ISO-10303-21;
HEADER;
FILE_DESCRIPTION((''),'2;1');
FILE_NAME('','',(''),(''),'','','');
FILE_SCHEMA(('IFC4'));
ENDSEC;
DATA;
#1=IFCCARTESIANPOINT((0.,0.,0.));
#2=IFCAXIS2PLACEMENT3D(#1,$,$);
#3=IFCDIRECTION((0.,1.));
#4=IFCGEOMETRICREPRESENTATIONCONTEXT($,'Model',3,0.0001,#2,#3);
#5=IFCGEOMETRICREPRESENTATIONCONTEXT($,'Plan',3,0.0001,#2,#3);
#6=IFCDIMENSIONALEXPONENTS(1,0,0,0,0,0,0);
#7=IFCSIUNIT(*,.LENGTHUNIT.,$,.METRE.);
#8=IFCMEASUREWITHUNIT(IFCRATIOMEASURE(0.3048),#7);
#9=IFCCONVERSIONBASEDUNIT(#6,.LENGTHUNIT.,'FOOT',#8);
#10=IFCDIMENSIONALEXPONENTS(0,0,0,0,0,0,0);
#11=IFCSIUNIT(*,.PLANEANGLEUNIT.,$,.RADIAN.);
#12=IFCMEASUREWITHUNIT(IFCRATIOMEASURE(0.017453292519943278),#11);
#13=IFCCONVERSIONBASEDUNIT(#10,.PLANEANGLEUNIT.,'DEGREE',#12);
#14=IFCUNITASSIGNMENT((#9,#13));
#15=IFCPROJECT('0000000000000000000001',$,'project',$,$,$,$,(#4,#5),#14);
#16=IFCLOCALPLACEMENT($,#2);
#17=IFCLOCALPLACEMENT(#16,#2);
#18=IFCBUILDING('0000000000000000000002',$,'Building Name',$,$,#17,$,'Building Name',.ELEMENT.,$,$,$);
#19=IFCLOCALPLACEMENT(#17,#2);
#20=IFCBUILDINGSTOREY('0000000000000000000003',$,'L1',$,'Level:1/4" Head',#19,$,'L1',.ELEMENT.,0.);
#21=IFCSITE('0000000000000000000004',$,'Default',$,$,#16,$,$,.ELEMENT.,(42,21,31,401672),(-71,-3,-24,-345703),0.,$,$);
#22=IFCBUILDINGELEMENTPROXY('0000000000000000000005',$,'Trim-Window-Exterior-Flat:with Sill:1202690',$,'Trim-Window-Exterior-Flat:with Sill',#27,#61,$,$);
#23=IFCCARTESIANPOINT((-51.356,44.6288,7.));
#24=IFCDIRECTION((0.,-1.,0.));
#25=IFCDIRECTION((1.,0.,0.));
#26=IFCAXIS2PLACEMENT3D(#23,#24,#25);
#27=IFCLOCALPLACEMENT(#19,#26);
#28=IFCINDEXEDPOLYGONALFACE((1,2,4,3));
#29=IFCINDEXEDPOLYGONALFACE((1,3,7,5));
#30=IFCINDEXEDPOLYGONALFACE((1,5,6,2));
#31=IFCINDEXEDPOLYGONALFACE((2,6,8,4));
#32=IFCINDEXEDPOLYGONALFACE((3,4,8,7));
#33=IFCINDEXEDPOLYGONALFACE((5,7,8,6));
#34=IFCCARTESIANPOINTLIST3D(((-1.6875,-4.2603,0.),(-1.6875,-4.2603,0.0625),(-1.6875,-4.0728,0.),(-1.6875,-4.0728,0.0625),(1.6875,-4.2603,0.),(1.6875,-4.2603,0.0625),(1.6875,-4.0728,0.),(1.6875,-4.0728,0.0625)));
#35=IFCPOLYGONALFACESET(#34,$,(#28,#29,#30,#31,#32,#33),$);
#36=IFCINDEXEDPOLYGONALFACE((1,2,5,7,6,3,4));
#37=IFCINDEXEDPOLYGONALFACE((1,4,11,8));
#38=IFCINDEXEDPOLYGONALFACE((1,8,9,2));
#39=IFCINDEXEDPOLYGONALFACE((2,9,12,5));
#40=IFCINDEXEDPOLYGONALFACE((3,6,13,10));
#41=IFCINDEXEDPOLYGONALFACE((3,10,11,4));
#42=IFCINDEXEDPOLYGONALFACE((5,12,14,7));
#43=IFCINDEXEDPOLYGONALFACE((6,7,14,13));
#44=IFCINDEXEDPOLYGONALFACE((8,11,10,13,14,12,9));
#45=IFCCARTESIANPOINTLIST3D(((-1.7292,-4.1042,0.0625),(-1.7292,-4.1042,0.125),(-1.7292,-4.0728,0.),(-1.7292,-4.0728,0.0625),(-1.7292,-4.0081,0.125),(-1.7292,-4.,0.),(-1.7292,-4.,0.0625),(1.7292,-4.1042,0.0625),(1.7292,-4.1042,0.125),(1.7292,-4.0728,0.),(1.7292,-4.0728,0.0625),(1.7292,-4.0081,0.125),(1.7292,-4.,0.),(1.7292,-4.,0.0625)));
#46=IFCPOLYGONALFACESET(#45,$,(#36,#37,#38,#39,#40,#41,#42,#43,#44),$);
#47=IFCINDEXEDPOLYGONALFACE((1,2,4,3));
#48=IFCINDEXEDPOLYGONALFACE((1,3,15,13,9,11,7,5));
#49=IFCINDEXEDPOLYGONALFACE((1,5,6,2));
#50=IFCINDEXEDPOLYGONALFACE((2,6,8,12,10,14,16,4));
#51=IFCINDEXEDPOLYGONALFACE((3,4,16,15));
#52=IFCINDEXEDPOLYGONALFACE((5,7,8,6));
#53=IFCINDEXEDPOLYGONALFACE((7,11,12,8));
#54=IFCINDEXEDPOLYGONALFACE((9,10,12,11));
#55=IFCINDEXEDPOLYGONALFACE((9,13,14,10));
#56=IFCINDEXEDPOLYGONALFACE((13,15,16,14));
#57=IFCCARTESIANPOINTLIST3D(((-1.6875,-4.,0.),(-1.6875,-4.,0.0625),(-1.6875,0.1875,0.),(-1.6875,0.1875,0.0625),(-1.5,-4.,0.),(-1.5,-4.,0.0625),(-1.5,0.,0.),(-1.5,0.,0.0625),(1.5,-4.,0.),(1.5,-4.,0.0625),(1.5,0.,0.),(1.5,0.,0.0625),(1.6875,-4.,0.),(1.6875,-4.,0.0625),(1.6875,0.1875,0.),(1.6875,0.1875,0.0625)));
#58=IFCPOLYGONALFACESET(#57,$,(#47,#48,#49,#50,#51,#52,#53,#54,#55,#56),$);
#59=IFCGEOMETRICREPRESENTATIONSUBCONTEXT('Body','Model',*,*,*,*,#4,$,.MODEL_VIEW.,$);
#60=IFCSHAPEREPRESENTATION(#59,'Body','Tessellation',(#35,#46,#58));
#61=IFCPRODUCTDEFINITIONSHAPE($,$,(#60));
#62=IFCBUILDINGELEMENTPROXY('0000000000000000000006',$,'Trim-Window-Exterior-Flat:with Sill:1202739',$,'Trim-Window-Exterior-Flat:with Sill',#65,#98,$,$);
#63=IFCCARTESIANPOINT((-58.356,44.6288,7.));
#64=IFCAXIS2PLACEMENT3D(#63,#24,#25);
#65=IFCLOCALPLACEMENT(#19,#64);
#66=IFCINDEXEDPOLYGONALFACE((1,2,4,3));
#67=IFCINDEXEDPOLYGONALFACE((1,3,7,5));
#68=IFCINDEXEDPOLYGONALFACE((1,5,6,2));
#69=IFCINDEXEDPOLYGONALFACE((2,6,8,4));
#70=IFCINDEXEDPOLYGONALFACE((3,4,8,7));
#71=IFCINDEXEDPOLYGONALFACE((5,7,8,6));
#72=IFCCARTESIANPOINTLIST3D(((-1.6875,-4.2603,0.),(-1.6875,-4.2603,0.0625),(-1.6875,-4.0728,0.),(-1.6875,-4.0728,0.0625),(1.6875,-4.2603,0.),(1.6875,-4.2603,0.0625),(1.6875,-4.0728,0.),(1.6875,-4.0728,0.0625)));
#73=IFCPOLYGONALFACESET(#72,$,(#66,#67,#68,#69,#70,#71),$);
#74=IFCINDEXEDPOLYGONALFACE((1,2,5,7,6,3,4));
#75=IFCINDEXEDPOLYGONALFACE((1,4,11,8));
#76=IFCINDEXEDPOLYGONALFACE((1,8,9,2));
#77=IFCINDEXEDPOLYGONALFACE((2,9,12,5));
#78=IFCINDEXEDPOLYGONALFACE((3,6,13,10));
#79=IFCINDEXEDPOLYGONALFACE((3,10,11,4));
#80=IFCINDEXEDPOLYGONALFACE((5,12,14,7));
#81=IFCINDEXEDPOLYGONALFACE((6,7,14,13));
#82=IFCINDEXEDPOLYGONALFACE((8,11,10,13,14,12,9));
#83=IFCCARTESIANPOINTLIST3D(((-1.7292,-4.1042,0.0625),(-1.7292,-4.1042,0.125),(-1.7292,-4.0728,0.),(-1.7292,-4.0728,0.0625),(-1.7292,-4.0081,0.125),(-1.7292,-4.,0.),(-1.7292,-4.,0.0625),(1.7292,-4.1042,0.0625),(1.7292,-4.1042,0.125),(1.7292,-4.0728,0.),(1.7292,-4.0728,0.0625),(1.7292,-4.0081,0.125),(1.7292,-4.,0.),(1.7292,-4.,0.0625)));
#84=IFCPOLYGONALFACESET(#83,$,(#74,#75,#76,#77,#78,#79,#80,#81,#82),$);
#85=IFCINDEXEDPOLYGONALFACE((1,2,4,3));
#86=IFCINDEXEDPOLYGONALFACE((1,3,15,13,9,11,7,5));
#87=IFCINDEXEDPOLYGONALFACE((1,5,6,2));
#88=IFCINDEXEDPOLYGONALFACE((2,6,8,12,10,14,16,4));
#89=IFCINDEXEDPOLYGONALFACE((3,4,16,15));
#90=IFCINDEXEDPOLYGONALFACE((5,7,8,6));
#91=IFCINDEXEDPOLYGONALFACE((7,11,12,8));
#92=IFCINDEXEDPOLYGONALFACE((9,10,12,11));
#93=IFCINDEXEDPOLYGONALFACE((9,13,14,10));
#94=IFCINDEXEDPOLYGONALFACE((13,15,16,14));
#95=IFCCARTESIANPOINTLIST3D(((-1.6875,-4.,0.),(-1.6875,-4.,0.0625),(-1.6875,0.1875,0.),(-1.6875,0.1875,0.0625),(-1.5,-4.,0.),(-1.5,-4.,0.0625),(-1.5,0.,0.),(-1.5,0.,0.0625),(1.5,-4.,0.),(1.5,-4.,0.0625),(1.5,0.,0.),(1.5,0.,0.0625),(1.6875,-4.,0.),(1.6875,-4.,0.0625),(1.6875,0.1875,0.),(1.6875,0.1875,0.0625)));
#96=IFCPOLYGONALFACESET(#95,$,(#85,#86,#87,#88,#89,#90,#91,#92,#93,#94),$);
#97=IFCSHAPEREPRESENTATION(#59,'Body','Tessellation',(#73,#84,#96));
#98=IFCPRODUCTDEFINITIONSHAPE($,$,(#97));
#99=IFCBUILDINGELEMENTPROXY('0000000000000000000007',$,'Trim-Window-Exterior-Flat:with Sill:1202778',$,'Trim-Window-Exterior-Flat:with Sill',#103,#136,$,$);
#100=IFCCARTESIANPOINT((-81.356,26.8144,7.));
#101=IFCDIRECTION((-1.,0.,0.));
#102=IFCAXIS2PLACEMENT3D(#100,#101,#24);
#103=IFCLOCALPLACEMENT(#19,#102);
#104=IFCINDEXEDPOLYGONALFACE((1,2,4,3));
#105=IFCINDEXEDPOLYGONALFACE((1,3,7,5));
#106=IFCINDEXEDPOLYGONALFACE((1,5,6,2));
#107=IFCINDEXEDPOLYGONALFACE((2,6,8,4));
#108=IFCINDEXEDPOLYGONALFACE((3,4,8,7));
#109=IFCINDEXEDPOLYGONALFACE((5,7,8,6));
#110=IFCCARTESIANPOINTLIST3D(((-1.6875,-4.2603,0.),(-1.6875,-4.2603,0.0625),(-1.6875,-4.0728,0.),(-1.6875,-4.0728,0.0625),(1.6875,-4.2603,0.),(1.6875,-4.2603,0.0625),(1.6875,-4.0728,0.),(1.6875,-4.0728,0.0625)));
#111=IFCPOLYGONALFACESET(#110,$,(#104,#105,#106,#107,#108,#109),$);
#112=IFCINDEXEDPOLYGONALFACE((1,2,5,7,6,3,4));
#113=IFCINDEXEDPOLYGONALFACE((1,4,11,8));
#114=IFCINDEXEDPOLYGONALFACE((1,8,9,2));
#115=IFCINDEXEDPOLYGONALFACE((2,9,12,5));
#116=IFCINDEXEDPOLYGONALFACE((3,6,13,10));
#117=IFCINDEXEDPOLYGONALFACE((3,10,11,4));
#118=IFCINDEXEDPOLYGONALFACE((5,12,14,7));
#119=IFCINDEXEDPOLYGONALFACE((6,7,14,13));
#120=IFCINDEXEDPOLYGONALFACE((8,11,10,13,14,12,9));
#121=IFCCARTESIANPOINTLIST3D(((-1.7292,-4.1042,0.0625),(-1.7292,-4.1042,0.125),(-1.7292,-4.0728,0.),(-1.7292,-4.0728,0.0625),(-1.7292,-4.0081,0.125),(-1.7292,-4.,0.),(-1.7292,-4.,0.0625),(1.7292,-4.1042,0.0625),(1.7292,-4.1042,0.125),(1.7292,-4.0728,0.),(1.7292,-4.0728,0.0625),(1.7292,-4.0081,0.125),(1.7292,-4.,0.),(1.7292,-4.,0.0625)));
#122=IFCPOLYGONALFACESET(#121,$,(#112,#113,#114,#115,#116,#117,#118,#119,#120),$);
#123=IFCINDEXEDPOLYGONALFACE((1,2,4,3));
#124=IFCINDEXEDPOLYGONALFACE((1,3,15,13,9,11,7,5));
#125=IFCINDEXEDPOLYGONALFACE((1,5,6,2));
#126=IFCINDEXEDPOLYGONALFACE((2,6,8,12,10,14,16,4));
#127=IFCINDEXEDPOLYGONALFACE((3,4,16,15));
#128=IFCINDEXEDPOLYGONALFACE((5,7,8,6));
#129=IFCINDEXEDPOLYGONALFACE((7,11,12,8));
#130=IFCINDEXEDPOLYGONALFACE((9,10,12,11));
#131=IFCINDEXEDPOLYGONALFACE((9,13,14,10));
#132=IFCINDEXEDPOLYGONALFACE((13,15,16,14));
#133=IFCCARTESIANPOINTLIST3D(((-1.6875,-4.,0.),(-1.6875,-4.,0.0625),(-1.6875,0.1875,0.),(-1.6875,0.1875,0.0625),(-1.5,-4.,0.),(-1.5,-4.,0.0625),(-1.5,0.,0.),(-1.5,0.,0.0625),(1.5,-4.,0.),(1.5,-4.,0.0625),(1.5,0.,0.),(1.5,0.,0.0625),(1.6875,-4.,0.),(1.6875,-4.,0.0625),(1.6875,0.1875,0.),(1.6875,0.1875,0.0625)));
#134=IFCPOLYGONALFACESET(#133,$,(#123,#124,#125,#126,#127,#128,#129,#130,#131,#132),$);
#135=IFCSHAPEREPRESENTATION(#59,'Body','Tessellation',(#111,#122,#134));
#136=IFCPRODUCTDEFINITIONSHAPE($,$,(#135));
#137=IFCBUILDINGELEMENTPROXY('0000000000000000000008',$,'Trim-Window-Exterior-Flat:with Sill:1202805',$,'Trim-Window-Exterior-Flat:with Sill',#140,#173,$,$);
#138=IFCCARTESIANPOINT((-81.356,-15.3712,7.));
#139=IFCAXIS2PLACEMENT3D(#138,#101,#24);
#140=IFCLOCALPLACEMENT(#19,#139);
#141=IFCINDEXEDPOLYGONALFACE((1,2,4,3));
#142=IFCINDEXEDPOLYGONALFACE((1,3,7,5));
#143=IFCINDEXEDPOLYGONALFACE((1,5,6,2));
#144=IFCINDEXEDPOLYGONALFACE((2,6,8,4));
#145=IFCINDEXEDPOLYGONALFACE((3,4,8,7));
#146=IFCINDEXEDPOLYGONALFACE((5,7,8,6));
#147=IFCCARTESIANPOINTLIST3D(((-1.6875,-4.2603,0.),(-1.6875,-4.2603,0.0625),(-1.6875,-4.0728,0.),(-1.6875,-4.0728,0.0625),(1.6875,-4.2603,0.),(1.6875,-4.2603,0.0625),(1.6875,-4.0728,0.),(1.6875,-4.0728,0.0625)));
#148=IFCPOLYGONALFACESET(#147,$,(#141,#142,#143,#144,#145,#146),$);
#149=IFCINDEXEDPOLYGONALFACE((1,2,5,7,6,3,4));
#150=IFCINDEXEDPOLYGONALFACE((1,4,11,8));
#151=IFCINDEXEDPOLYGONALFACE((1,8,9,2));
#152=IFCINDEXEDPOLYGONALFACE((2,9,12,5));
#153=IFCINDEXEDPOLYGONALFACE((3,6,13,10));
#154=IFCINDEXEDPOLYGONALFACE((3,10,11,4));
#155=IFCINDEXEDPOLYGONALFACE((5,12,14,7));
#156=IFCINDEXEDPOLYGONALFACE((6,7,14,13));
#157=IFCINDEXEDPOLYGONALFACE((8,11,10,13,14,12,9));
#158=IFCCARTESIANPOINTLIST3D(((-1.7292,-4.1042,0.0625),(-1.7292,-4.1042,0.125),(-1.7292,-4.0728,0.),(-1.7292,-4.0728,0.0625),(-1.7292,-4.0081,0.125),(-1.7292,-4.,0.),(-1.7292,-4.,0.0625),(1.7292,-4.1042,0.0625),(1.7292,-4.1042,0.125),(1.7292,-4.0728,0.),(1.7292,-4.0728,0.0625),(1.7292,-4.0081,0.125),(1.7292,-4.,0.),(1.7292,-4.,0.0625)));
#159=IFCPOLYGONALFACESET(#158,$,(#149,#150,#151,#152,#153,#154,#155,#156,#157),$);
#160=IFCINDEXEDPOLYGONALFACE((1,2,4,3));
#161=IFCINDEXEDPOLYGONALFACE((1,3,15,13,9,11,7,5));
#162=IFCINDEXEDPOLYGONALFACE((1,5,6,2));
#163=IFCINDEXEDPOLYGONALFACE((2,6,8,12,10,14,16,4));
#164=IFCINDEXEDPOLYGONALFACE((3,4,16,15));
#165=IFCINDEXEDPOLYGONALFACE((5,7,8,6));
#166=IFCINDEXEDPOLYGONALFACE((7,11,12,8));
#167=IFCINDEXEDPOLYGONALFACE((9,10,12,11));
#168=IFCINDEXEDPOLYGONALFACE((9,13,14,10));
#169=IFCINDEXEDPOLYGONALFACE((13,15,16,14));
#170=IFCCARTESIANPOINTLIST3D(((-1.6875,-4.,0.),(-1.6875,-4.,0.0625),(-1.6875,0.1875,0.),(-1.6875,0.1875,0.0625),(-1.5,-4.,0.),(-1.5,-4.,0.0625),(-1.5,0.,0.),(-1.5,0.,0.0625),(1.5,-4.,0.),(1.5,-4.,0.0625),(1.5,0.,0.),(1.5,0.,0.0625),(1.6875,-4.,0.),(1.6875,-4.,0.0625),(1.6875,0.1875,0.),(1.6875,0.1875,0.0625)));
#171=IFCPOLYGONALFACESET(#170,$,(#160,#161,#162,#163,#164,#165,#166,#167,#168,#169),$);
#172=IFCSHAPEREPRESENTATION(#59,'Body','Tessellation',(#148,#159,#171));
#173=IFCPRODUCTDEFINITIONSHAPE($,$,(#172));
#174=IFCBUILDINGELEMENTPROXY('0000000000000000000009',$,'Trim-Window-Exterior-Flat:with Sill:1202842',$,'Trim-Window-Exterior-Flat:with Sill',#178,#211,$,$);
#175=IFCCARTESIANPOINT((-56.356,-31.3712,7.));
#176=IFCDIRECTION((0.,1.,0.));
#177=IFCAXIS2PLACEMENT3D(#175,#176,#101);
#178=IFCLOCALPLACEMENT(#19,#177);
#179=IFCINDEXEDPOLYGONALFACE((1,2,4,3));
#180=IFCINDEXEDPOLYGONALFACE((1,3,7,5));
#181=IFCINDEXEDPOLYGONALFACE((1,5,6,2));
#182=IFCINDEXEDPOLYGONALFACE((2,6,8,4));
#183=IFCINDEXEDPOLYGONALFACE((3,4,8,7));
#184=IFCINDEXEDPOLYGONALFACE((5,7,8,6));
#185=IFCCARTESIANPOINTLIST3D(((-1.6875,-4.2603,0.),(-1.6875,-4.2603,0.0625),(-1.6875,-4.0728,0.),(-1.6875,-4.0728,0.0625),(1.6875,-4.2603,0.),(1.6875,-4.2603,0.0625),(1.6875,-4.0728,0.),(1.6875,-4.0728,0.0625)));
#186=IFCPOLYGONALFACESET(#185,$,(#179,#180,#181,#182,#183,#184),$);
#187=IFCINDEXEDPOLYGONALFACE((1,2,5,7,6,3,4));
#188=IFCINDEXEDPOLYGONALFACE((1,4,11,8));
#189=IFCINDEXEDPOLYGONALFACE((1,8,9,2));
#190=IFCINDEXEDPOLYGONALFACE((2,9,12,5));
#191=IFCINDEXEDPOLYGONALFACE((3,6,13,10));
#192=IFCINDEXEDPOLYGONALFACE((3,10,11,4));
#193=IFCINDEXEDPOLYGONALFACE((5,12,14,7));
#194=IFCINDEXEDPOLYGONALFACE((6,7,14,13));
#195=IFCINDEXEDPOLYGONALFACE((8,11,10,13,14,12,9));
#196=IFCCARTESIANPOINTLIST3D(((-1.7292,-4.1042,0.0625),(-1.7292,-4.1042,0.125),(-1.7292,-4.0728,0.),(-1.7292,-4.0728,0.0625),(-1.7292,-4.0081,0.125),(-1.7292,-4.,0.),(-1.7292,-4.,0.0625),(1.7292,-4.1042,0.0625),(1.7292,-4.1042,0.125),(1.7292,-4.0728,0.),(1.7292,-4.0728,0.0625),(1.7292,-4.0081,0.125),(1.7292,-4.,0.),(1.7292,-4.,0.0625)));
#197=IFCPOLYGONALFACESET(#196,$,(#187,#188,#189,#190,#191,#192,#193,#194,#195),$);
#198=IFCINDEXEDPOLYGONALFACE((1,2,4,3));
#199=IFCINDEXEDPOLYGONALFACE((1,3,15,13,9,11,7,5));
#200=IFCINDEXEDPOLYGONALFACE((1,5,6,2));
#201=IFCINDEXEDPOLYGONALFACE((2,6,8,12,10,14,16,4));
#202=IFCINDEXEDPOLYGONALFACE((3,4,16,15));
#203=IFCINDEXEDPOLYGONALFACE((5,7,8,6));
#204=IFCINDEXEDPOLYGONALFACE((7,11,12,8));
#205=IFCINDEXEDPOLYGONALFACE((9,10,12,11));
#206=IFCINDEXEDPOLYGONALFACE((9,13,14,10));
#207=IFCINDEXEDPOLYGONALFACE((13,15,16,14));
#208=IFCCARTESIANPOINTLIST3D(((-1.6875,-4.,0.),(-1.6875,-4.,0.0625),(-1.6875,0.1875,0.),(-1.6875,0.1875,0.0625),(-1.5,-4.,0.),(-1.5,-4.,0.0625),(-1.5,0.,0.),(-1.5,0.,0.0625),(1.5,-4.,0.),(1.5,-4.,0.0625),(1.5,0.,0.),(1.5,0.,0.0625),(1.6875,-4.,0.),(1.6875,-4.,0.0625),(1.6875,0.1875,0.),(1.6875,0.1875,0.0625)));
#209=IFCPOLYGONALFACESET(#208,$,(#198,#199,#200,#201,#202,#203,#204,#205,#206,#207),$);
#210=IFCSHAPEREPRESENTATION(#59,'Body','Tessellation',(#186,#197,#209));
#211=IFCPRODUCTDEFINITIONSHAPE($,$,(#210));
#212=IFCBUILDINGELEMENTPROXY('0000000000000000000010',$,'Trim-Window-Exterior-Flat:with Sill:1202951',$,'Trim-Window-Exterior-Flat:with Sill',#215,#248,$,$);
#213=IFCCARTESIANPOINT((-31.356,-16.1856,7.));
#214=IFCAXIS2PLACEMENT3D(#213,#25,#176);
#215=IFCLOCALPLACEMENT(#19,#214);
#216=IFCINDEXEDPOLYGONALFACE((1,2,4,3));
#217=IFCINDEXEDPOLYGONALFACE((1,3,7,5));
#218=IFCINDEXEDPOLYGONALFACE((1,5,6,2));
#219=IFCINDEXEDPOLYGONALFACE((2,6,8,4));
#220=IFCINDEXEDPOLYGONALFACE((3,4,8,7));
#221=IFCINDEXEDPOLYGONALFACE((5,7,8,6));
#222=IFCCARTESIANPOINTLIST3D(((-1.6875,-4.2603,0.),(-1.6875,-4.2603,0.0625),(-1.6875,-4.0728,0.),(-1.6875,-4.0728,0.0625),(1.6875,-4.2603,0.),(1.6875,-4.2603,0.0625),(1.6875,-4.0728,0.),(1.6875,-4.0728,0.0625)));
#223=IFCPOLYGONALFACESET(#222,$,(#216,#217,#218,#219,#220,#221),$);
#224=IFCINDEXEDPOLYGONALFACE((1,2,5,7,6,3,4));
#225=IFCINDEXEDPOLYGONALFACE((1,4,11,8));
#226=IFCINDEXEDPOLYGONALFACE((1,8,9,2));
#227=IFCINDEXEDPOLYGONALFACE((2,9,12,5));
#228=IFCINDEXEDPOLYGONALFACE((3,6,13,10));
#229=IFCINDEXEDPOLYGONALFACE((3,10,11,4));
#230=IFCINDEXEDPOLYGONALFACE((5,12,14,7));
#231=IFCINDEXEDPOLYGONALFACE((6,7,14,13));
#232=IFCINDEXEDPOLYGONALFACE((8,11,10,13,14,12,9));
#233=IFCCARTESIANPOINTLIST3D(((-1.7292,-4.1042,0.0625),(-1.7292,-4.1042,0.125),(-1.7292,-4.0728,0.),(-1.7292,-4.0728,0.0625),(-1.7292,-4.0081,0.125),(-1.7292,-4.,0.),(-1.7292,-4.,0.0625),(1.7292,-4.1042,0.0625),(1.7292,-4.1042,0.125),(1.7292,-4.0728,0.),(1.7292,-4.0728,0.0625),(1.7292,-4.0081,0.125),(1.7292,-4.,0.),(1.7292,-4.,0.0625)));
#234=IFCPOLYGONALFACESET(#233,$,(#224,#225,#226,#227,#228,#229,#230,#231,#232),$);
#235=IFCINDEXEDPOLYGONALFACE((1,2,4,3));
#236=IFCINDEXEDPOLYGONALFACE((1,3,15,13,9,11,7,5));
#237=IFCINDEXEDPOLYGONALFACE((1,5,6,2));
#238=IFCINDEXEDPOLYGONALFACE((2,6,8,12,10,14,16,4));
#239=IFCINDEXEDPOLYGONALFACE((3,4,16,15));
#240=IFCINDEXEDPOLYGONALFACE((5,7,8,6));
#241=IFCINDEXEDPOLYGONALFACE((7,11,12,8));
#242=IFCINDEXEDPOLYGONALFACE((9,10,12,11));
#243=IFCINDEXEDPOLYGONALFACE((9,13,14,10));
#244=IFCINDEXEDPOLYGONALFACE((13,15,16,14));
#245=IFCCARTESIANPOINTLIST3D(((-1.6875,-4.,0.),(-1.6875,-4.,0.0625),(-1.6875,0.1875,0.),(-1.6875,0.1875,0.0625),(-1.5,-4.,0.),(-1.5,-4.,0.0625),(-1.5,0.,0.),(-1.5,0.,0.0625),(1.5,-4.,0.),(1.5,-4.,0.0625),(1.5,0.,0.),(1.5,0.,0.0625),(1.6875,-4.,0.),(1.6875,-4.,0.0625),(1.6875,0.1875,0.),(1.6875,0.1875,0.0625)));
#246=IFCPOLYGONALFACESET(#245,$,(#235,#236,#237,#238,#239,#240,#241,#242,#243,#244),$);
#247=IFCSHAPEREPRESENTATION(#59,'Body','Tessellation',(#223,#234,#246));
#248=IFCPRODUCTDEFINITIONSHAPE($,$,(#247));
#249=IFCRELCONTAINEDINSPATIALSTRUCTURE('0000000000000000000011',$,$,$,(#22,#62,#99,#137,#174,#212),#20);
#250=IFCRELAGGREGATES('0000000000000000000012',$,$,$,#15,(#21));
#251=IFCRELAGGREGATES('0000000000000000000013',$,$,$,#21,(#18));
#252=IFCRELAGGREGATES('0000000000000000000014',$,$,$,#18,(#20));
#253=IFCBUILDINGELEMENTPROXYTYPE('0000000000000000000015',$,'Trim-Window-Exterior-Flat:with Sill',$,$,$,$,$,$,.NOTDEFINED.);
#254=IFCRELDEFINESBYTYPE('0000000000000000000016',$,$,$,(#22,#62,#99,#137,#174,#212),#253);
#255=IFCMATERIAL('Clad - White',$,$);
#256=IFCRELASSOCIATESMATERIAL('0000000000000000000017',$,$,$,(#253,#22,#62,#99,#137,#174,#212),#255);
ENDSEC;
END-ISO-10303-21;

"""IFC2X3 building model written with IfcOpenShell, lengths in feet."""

from ifc_helpers import new_model, entity, si_unit, converted_unit, direction, frame, frame_2d, origin, place, context, subcontext, project, spatial, polyline, rectangle, outline, extrude, source, transform, mapped, material, type_object, type_shapes, element, save


model = new_model("IFC2X3")

# Units and contexts
model_context = context("Model", 3, precision=0.0001, world=origin(), true_north=direction((0.0, 1.0)))
plan_context = context("Plan", 3, precision=0.0001, world=origin(), true_north=direction((0.0, 1.0)))
body_context = subcontext(model_context, "Body", "Model", "MODEL_VIEW")
ifc_project = project(units=[converted_unit("LENGTHUNIT", "FOOT", entity("IfcRatioMeasure", 0.3048), si_unit("LENGTHUNIT", "METRE"), dimensions=[1, 0, 0, 0, 0, 0, 0]), converted_unit("PLANEANGLEUNIT", "DEGREE", entity("IfcRatioMeasure", 0.017453292519943278), si_unit("PLANEANGLEUNIT", "RADIAN"), dimensions=[0, 0, 0, 0, 0, 0, 0])], contexts=[model_context, plan_context])

# Site, building, storey
site_placement = place(None, origin())
site = spatial("IfcSite", under=ifc_project, at=site_placement, Name="Default", CompositionType="ELEMENT", RefLatitude=(42, 21, 31, 401672), RefLongitude=(-71, -3, -24, -345703), RefElevation=0.0)
building_placement = place(site_placement, origin())
building = spatial("IfcBuilding", under=site, at=building_placement, Name="Building Name", LongName="Building Name", CompositionType="ELEMENT")
storey_placement = place(building_placement, origin())
storey = spatial("IfcBuildingStorey", under=building, at=storey_placement, Name="L1", ObjectType="Level:1/4\" Head", LongName="L1", CompositionType="ELEMENT", Elevation=0.0)

# Building element proxies
ifc_material_1 = material(Name="Clad - White")
building_element_proxy_type_1 = type_object("IfcBuildingElementProxyType", Name="Trim-Window-Exterior-Flat:with Sill", PredefinedType="NOTDEFINED", material=ifc_material_1)
shared_shape_1 = source(origin(), body_context, "Body", "SweptSolid", [
    extrude(rectangle(XDim=3.375, YDim=0.1875, at=frame_2d((0.0, 0.0), x_axis=(1.0, 0.0))), frame((0.0, -4.1665, 0.0), z_axis=(0.0, 0.0, 1.0), x_axis=(-1.0, 0.0, 0.0)), (0.0, 0.0, 1.0), 0.0625),
    extrude(outline(polyline([(-0.0625, -0.0525), (0.0, -0.0525), (0.0, -0.0211), (0.0625, -0.0211), (0.0625, 0.0517), (0.0, 0.0517), (-0.0625, 0.0436), (-0.0625, -0.0525)])), frame((-1.7292, -4.0517, 0.0625), z_axis=(1.0, 0.0, 0.0), x_axis=(0.0, 0.0, -1.0)), (0.0, 0.0, 1.0), 3.4583),
    extrude(outline(polyline([(-2.1406, -1.6875), (2.0469, -1.6875), (2.0469, -1.5), (-1.9531, -1.5), (-1.9531, 1.5), (2.0469, 1.5), (2.0469, 1.6875), (-2.1406, 1.6875), (-2.1406, -1.6875)])), frame((0.0, -1.9531, 0.0), z_axis=(0.0, 0.0, 1.0), x_axis=(0.0, -1.0, 0.0)), (0.0, 0.0, 1.0), 0.0625),
])
type_shapes(building_element_proxy_type_1, [shared_shape_1])
for number, where, z_axis, x_axis, name in (
    (1, (-51.356, 44.6288, 7.0), (0.0, -1.0, 0.0), (1.0, 0.0, 0.0), "Trim-Window-Exterior-Flat:with Sill:1202690"),
    (2, (-58.356, 44.6288, 7.0), (0.0, -1.0, 0.0), (1.0, 0.0, 0.0), "Trim-Window-Exterior-Flat:with Sill:1202739"),
    (3, (-81.356, 26.8144, 7.0), (-1.0, 0.0, 0.0), (0.0, -1.0, 0.0), "Trim-Window-Exterior-Flat:with Sill:1202778"),
    (4, (-81.356, -15.3712, 7.0), (-1.0, 0.0, 0.0), (0.0, -1.0, 0.0), "Trim-Window-Exterior-Flat:with Sill:1202805"),
    (5, (-56.356, -31.3712, 7.0), (0.0, 1.0, 0.0), (-1.0, 0.0, 0.0), "Trim-Window-Exterior-Flat:with Sill:1202842"),
    (6, (-31.356, -16.1856, 7.0), (1.0, 0.0, 0.0), (0.0, 1.0, 0.0), "Trim-Window-Exterior-Flat:with Sill:1202951"),
):
    element("IfcBuildingElementProxy", number, at=place(storey_placement, frame(where, z_axis=z_axis, x_axis=x_axis)), inside=storey, type_object=building_element_proxy_type_1, material=ifc_material_1, Name=name, ObjectType="Trim-Window-Exterior-Flat:with Sill", context=body_context, shape_type="MappedRepresentation", body=[
        mapped(shared_shape_1, transform((0.0, 0.0, 0.0), scale=1.0)),
    ])

save(model, "model.ifc")
